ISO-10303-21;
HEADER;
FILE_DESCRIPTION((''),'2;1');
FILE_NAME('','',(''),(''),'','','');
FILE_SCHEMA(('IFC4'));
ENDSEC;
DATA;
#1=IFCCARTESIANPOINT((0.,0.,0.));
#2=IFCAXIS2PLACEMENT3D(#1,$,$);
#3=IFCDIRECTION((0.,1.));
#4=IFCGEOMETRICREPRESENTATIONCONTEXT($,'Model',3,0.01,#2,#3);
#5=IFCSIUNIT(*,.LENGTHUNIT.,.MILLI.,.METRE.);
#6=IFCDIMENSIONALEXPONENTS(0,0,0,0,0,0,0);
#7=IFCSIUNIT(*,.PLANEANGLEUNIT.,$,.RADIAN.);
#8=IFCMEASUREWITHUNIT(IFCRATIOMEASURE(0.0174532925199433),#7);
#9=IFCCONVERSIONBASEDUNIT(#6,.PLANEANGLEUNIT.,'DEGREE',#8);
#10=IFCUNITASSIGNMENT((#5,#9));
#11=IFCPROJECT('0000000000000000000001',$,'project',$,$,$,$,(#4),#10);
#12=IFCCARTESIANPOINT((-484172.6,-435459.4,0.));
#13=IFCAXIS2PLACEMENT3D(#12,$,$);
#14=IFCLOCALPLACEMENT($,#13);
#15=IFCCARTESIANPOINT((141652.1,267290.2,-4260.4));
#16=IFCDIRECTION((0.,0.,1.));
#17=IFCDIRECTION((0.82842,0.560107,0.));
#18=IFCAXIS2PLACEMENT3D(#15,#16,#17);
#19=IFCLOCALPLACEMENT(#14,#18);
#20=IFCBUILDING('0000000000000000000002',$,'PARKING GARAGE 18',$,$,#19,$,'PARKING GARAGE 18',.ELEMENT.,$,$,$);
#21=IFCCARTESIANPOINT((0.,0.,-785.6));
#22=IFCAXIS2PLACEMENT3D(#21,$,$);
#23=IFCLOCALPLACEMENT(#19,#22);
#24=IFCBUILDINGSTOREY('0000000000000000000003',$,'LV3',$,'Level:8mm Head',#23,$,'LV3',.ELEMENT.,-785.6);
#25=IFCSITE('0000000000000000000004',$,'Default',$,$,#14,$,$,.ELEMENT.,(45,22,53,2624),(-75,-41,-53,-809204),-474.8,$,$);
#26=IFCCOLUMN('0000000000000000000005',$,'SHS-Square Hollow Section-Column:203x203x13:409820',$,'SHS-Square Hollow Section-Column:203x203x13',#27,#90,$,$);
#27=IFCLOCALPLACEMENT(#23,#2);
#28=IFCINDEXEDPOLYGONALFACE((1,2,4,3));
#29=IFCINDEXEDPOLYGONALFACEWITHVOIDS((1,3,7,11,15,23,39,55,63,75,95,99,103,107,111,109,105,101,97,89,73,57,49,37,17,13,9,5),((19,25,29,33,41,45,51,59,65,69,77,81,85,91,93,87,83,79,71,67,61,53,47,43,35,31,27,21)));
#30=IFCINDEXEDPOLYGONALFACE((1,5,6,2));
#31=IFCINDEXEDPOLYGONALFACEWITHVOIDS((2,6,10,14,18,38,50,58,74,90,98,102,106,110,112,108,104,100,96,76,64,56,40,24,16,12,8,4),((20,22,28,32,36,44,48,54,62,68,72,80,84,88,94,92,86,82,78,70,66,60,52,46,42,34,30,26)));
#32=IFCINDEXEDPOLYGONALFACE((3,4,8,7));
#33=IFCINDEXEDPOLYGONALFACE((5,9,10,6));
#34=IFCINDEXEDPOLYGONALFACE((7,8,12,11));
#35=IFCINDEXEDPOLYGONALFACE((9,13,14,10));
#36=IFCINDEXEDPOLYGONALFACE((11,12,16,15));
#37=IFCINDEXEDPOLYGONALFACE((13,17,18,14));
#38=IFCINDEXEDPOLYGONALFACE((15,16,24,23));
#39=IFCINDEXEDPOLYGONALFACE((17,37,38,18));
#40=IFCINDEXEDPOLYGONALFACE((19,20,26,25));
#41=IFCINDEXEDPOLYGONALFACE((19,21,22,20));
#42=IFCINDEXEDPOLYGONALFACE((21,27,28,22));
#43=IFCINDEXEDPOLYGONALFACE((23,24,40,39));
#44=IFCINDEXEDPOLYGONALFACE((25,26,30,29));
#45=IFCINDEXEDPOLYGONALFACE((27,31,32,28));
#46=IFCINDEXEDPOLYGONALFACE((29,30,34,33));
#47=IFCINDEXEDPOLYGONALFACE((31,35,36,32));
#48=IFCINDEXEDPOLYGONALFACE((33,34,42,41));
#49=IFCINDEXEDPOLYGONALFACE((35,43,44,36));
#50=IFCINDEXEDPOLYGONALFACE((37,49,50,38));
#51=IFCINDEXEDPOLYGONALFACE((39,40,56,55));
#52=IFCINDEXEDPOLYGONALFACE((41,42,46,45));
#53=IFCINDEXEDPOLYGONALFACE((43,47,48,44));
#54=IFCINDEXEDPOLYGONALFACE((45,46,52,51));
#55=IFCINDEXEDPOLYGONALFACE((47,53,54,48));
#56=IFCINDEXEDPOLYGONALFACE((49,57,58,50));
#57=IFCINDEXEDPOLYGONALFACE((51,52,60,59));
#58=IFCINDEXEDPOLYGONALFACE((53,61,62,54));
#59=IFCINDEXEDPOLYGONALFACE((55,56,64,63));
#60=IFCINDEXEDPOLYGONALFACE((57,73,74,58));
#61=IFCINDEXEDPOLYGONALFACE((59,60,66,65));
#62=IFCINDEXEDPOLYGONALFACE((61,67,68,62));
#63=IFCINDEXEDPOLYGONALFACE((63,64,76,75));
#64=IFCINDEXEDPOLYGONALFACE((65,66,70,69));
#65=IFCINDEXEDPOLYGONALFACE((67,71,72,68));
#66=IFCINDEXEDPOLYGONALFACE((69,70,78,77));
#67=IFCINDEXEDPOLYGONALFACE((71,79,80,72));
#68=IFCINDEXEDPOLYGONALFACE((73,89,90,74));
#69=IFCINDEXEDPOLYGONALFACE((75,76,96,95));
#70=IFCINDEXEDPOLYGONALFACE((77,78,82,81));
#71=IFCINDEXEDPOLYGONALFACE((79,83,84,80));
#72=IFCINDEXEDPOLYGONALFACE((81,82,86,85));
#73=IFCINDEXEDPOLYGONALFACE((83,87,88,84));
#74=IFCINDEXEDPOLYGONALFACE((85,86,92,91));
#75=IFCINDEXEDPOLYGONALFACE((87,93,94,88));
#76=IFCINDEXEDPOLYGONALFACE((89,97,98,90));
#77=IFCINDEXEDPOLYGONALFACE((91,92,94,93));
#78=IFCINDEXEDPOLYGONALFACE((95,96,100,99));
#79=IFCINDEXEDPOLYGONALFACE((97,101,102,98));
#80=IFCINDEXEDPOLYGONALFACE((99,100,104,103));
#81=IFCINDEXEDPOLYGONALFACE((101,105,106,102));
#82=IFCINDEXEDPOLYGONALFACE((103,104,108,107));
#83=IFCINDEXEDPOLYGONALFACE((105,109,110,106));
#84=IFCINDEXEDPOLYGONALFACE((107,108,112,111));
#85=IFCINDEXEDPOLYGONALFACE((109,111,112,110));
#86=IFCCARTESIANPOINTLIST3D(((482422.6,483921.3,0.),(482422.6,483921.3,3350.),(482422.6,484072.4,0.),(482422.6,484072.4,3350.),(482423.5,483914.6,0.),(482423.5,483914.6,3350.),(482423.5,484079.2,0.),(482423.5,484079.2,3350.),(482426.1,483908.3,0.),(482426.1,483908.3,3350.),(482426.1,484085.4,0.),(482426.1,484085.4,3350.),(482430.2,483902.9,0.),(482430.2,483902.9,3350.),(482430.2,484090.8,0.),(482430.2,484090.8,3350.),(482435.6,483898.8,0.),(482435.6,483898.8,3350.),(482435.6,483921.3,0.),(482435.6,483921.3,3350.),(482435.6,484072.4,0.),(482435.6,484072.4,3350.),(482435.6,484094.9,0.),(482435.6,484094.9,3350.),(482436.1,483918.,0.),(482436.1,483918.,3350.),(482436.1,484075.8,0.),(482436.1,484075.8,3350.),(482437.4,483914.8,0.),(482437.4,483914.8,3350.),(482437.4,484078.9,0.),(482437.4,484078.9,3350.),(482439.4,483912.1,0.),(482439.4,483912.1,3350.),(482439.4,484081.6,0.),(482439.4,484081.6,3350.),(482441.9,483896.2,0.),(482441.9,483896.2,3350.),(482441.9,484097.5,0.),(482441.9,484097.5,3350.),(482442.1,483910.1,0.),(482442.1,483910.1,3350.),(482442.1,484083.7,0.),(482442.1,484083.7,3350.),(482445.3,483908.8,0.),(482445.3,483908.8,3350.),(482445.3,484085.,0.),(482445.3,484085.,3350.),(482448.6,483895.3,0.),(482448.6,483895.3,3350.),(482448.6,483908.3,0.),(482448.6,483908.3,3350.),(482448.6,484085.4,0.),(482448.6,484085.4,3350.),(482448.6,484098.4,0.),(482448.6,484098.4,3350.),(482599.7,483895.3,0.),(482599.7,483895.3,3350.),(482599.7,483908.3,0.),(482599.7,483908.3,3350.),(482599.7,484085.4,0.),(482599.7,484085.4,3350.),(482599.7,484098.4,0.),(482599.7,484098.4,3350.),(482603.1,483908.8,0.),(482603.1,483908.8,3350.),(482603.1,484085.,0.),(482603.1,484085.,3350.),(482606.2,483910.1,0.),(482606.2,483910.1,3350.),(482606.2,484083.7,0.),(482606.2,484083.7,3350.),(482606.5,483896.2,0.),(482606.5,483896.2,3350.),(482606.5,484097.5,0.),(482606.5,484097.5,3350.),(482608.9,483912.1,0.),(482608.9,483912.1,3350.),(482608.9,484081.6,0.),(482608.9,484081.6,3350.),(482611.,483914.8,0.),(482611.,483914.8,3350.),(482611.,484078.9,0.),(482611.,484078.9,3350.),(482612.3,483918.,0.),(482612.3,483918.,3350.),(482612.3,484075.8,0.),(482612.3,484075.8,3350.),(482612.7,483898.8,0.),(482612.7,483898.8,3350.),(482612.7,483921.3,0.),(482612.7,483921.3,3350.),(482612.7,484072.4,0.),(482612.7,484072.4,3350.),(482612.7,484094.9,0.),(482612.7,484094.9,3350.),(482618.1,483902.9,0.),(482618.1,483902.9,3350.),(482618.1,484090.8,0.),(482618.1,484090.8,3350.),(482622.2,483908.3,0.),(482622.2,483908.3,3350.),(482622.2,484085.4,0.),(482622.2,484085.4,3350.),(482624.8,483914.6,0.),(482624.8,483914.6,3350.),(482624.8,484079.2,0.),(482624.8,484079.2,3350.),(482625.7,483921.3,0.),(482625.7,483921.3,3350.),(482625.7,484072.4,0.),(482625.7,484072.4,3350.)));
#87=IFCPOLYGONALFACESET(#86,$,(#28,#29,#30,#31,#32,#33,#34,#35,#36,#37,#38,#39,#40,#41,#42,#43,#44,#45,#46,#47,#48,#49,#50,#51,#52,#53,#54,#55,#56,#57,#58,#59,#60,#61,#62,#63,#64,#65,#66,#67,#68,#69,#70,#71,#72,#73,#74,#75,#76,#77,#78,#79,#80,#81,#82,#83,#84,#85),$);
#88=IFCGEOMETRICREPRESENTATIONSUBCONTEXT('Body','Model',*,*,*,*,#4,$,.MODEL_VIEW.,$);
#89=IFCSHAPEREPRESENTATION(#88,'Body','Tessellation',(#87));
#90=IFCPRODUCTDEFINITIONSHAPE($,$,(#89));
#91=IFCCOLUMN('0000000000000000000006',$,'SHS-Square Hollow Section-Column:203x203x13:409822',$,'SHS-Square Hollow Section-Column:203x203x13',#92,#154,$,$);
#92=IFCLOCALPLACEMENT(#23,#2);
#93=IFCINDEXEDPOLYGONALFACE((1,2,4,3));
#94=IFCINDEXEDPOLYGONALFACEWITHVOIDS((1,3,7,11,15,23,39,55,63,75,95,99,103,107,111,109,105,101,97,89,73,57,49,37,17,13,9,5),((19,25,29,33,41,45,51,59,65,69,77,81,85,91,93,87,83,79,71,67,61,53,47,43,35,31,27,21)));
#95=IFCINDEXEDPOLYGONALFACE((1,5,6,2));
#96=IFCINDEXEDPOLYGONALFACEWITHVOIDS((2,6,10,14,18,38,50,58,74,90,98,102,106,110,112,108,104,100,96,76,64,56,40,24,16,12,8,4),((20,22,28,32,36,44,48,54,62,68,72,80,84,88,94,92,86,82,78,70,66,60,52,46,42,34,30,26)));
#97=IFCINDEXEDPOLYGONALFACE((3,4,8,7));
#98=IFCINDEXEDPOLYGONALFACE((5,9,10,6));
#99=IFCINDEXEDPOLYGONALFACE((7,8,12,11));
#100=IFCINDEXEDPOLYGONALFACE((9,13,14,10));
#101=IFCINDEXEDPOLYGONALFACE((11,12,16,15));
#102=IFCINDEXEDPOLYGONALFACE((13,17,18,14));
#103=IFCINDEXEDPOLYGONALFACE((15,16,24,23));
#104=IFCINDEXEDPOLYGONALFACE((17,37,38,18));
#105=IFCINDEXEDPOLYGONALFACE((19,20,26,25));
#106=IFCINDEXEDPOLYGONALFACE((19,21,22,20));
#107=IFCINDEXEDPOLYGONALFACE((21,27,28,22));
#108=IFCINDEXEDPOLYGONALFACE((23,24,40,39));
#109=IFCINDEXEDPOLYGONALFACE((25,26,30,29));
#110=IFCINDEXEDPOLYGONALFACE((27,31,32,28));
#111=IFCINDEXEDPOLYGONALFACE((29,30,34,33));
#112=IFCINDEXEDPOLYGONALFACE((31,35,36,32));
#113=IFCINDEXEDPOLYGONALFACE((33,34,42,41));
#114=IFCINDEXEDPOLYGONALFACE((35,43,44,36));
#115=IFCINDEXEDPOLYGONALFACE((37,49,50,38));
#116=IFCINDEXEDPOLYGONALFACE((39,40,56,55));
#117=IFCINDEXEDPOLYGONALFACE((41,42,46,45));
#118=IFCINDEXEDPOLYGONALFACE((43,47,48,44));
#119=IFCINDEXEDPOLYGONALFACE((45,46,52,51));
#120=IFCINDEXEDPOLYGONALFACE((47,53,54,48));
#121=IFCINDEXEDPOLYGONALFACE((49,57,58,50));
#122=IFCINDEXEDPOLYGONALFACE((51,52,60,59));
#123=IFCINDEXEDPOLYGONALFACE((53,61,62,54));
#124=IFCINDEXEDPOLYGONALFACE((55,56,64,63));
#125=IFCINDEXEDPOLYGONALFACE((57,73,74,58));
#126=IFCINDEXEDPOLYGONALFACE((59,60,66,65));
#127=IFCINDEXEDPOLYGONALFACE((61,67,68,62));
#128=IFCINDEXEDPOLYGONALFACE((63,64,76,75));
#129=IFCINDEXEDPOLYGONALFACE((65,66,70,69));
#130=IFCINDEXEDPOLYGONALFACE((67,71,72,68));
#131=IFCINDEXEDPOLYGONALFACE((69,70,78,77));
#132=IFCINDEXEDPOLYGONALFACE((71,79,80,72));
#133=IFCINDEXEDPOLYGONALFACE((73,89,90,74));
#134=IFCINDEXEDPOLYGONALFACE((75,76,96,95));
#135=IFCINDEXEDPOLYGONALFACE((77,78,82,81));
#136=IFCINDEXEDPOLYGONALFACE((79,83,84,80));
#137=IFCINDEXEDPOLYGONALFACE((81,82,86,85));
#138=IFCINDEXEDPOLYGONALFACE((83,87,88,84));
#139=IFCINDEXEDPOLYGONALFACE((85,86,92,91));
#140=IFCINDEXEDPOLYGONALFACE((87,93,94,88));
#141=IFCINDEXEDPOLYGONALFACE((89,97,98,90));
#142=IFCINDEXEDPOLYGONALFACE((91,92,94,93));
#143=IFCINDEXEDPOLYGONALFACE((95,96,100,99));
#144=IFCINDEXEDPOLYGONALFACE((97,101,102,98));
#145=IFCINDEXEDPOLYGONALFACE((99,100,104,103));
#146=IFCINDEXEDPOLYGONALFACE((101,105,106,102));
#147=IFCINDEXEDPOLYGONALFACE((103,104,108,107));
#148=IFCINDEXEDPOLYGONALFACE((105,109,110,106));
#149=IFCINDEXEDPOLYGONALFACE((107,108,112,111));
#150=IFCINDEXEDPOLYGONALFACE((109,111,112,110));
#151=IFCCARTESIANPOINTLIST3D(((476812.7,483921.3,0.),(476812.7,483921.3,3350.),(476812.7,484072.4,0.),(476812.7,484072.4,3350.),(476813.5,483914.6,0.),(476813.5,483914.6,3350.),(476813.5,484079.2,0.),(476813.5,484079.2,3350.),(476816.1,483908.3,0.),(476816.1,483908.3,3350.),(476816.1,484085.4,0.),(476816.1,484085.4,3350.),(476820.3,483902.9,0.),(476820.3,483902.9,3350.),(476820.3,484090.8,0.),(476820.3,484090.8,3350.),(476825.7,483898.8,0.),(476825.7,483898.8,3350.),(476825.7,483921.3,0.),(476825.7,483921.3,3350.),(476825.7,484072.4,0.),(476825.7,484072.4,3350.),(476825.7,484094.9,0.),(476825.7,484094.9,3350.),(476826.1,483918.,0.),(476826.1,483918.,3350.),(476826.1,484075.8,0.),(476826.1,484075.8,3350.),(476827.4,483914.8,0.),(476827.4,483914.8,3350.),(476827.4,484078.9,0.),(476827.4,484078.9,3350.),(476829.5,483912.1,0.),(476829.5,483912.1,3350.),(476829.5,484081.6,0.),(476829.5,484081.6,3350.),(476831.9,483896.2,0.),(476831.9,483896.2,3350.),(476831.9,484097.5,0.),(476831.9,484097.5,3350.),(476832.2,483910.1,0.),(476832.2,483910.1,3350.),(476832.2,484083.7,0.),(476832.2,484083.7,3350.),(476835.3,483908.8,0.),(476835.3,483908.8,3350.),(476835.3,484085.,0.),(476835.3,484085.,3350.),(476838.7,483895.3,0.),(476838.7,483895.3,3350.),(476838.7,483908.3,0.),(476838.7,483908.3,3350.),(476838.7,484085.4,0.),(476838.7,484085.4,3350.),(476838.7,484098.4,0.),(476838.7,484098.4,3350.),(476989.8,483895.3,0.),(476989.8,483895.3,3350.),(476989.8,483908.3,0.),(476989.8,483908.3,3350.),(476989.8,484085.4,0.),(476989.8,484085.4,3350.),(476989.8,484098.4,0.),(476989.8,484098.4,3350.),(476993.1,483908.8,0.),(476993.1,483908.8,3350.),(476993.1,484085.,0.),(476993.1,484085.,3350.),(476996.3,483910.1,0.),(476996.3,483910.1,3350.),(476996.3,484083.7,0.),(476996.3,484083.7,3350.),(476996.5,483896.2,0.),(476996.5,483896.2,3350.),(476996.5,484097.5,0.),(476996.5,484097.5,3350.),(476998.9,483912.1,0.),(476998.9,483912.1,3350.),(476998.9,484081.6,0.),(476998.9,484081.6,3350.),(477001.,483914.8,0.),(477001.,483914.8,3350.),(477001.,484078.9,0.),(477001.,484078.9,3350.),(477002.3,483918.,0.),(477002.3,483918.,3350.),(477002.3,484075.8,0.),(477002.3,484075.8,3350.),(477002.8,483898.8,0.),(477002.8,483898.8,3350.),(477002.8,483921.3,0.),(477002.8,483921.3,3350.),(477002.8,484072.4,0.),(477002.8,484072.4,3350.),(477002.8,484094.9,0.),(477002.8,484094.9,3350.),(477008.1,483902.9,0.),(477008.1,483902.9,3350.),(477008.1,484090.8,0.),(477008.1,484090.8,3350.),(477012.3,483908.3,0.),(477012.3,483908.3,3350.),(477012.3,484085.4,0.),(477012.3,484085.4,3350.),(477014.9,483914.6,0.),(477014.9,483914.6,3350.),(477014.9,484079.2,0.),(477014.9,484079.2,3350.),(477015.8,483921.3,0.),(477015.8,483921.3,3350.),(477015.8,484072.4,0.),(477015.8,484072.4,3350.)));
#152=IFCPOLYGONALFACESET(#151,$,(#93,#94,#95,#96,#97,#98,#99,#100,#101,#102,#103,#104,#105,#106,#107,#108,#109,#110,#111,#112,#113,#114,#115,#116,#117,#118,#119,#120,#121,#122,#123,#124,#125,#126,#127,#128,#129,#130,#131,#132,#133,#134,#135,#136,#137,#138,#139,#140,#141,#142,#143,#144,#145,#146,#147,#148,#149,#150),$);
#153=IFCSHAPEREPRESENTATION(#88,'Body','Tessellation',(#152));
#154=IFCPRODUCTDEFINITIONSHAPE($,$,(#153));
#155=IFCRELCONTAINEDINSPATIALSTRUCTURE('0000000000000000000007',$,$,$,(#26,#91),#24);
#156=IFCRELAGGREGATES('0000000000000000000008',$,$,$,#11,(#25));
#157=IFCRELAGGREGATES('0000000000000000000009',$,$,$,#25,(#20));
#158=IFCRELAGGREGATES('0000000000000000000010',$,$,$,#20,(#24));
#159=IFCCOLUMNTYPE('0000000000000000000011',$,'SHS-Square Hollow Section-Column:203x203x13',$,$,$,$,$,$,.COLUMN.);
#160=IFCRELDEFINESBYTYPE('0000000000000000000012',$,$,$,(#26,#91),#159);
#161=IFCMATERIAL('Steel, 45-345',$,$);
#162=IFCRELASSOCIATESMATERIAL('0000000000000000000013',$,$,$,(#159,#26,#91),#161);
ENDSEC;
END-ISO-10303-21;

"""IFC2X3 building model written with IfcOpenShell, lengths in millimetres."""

from ifc_helpers import new_model, entity, si_unit, converted_unit, direction, frame, frame_2d, origin, place, context, subcontext, project, spatial, polyline, circle_curve, parameter, trimmed, segment, composite_curve, outline, extrude, source, transform, mapped, material, type_object, type_shapes, element, save


model = new_model("IFC2X3")

# Units and contexts
model_context = context("Model", 3, precision=0.01, world=origin(), true_north=direction((0.0, 1.0)))
body_context = subcontext(model_context, "Body", "Model", "MODEL_VIEW")
ifc_project = project(units=[si_unit("LENGTHUNIT", "METRE", prefix="MILLI"), converted_unit("PLANEANGLEUNIT", "DEGREE", entity("IfcRatioMeasure", 0.0174532925199433), si_unit("PLANEANGLEUNIT", "RADIAN"), dimensions=[0, 0, 0, 0, 0, 0, 0])], contexts=[model_context])

# Site, building, storey
site_placement = place(None, frame((-484172.6, -435459.4, 0.0)))
site = spatial("IfcSite", under=ifc_project, at=site_placement, Name="Default", CompositionType="ELEMENT", RefLatitude=(45, 22, 53, 2624), RefLongitude=(-75, -41, -53, -809204), RefElevation=-474.8)
building_placement = place(site_placement, frame((141652.1, 267290.2, -4260.4), z_axis=(0.0, 0.0, 1.0), x_axis=(0.82842, 0.560107, 0.0)))
building = spatial("IfcBuilding", under=site, at=building_placement, Name="PARKING GARAGE 18", LongName="PARKING GARAGE 18", CompositionType="ELEMENT")
storey_placement = place(building_placement, frame((0.0, 0.0, -785.6)))
storey = spatial("IfcBuildingStorey", under=building, at=storey_placement, Name="LV3", ObjectType="Level:8mm Head", LongName="LV3", CompositionType="ELEMENT", Elevation=-785.6)

# Columns
ifc_material_1 = material(Name="Steel, 45-345")
column_type_1 = type_object("IfcColumnType", Name="SHS-Square Hollow Section-Column:203x203x13", PredefinedType="COLUMN", material=ifc_material_1)
shared_shape_1 = source(origin(), body_context, "Body", "SweptSolid", [
    extrude(outline(composite_curve([segment(polyline([(-75.6, -101.5), (75.6, -101.5)]), True, "CONTINUOUS"), segment(trimmed(circle_curve(frame_2d((75.6, -75.6), x_axis=(-1.0, 0.0)), 26.0), [parameter(90.0)], [parameter(180.0)], True, "PARAMETER"), True, "CONTINUOUS"), segment(polyline([(101.5, -75.6), (101.5, 75.6)]), True, "CONTINUOUS"), segment(trimmed(circle_curve(frame_2d((75.5, 75.6), x_axis=(-1.0, 0.0)), 26.0), [parameter(180.0)], [parameter(270.0)], True, "PARAMETER"), True, "CONTINUOUS"), segment(polyline([(75.5, 101.6), (-75.5, 101.6)]), True, "CONTINUOUS"), segment(trimmed(circle_curve(frame_2d((-75.5, 75.5), x_axis=(-1.0, 0.0)), 26.0), [parameter(270.0)], [parameter(360.0)], True, "PARAMETER"), True, "CONTINUOUS"), segment(polyline([(-101.5, 75.5), (-101.5, -75.6)]), True, "CONTINUOUS"), segment(trimmed(circle_curve(frame_2d((-75.6, -75.6), x_axis=(-1.0, 0.0)), 26.0), [parameter(360.0)], [parameter(90.0)], True, "PARAMETER"), True, "CONTINUOUS")], self_intersect=False), holes=[composite_curve([segment(trimmed(circle_curve(frame_2d((-75.6, -75.6), x_axis=(-1.0, 0.0)), 13.0), [parameter(0.0)], [parameter(90.0)], True, "PARAMETER"), False, "CONTINUOUS"), segment(polyline([(-88.5, -75.6), (-88.5, 75.6)]), True, "CONTINUOUS"), segment(trimmed(circle_curve(frame_2d((-75.6, 75.6), x_axis=(-1.0, 0.0)), 13.0), [parameter(270.0)], [parameter(0.0)], True, "PARAMETER"), False, "CONTINUOUS"), segment(polyline([(-75.6, 88.6), (75.5, 88.6)]), True, "CONTINUOUS"), segment(trimmed(circle_curve(frame_2d((75.5, 75.5), x_axis=(-1.0, 0.0)), 13.0), [parameter(180.0)], [parameter(270.0)], True, "PARAMETER"), False, "CONTINUOUS"), segment(polyline([(88.6, 75.5), (88.6, -75.5)]), True, "CONTINUOUS"), segment(trimmed(circle_curve(frame_2d((75.6, -75.5), x_axis=(-1.0, 0.0)), 13.0), [parameter(90.0)], [parameter(180.0)], True, "PARAMETER"), False, "CONTINUOUS"), segment(polyline([(75.6, -88.5), (-75.6, -88.5)]), True, "CONTINUOUS")], self_intersect=False)]), frame((0.0, 0.0, -785.6), z_axis=(0.0, 0.0, 1.0), x_axis=(-1.0, 0.0, 0.0)), (0.0, 0.0, 1.0), 3350.0),
])
type_shapes(column_type_1, [shared_shape_1])
for number, where, name in (
    (1, (482524.2, 483996.9, 785.6), "SHS-Square Hollow Section-Column:203x203x13:409820"),
    (2, (476914.2, 483996.9, 785.6), "SHS-Square Hollow Section-Column:203x203x13:409822"),
):
    element("IfcColumn", number, at=place(storey_placement, frame(where)), inside=storey, type_object=column_type_1, material=ifc_material_1, Name=name, ObjectType="SHS-Square Hollow Section-Column:203x203x13", context=body_context, shape_type="MappedRepresentation", body=[
        mapped(shared_shape_1, transform((0.0, 0.0, 0.0), scale=1.0)),
    ])

save(model, "model.ifc")
